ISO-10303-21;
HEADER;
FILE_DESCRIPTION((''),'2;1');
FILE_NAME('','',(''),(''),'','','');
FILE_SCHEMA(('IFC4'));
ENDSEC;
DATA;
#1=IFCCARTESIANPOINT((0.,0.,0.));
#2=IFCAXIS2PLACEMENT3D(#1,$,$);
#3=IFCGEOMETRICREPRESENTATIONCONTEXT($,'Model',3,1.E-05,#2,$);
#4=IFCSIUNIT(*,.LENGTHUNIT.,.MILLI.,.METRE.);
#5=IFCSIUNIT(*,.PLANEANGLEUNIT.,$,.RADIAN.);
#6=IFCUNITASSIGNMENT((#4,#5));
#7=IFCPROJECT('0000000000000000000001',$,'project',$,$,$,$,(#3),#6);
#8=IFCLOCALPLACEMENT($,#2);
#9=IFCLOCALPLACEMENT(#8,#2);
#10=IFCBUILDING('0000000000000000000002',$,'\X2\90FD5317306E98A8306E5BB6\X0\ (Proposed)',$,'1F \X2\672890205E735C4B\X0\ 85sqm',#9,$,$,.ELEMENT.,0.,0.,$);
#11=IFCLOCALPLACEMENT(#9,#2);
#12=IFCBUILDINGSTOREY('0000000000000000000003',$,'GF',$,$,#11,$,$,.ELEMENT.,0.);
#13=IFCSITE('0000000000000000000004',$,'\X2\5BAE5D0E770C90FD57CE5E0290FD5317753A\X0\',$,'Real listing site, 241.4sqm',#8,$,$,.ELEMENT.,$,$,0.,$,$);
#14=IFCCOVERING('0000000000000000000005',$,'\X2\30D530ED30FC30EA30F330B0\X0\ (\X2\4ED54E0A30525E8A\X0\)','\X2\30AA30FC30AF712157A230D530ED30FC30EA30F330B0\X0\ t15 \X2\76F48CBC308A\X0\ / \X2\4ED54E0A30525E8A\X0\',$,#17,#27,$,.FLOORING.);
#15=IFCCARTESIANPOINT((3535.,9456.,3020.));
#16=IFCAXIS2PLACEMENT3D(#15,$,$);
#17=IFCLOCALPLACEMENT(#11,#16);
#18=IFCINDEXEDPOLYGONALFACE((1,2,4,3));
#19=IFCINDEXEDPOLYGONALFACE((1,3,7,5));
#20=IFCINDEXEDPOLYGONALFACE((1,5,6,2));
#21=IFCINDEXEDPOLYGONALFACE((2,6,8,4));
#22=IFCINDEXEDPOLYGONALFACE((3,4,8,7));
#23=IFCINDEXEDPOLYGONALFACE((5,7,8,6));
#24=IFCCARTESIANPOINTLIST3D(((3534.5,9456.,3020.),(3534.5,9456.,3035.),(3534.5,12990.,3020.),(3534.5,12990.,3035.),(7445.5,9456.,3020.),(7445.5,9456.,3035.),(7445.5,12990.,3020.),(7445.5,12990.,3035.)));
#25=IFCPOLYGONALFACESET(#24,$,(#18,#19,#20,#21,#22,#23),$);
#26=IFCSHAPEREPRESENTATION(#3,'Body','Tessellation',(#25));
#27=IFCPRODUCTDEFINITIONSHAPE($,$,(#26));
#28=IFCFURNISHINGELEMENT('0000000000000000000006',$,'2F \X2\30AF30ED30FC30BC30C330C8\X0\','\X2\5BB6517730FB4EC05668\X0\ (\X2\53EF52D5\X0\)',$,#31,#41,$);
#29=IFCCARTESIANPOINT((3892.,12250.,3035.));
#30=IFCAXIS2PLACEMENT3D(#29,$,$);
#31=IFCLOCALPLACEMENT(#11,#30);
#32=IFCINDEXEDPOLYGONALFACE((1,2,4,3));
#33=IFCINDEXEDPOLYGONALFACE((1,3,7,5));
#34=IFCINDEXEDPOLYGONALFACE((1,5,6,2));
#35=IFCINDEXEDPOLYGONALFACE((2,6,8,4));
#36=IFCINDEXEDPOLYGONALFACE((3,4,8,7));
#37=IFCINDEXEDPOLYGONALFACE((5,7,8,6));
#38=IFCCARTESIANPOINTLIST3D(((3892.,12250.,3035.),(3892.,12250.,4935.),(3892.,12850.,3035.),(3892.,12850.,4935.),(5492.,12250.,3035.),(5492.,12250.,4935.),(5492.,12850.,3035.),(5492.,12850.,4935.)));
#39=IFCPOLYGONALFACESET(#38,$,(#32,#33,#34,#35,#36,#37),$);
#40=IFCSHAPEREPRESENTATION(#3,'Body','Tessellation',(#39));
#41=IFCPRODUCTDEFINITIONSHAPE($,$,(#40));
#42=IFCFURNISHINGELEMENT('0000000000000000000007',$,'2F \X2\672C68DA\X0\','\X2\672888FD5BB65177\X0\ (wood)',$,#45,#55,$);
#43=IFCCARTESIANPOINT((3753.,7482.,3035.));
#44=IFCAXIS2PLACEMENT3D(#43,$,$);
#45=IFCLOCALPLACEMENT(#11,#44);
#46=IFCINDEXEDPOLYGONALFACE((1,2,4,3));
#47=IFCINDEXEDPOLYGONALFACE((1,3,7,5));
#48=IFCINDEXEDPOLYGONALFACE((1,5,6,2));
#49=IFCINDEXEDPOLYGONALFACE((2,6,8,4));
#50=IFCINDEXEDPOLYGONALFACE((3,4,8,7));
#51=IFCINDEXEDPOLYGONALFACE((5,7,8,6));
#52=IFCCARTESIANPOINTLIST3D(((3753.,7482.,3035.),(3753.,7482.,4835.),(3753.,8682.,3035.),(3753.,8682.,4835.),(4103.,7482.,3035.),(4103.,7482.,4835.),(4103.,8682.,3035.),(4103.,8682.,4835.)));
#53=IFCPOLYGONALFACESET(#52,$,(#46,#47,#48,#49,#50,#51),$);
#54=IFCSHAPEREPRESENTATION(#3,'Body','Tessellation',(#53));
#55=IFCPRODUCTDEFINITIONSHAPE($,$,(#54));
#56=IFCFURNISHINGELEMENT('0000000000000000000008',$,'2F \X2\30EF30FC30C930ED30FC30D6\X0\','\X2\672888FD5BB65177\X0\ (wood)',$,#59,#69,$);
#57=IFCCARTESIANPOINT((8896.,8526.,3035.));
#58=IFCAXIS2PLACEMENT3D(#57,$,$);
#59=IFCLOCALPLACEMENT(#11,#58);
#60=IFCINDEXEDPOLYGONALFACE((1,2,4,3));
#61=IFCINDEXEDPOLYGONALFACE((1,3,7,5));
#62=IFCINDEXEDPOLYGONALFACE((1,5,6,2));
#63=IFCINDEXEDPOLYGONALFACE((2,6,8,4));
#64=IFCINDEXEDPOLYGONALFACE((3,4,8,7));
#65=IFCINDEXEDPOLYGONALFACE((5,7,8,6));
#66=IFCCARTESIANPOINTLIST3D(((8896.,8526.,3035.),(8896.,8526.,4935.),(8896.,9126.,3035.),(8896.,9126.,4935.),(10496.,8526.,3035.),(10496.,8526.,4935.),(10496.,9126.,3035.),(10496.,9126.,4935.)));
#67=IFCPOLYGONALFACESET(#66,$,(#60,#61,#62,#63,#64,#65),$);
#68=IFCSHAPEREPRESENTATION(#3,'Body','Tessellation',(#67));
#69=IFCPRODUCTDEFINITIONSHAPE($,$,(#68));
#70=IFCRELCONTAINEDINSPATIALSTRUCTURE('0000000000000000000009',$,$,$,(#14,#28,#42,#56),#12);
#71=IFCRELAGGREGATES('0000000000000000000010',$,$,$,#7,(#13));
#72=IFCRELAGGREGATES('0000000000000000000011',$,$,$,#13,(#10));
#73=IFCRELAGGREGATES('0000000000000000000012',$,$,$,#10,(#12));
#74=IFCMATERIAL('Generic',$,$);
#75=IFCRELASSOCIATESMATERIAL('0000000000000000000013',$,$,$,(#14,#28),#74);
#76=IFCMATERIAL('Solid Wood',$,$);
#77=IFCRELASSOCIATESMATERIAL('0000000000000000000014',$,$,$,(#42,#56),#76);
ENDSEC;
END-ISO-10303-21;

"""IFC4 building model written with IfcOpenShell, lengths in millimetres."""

from ifc_helpers import new_model, si_unit, frame, frame_2d, origin, place, context, project, spatial, rectangle, extrude, material, element, save


model = new_model("IFC4")

# Units and contexts
model_context = context("Model", 3, precision=1e-05, world=origin())
ifc_project = project(units=[si_unit("LENGTHUNIT", "METRE", prefix="MILLI"), si_unit("PLANEANGLEUNIT", "RADIAN")], contexts=[model_context])

# Site, building, storey
site_placement = place(None, origin())
site = spatial("IfcSite", under=ifc_project, at=site_placement, Name="宮崎県都城市都北町", ObjectType="Real listing site, 241.4sqm", CompositionType="ELEMENT", RefElevation=0.0)
building_placement = place(site_placement, origin())
building = spatial("IfcBuilding", under=site, at=building_placement, Name="都北の風の家 (Proposed)", ObjectType="1F 木造平屋 85sqm", CompositionType="ELEMENT", ElevationOfRefHeight=0.0, ElevationOfTerrain=0.0)
storey_placement = place(building_placement, origin())
storey = spatial("IfcBuildingStorey", under=building, at=storey_placement, Name="GF", CompositionType="ELEMENT", Elevation=0.0)

# Shared definitions
ifc_material_1 = material(Name="Solid Wood")

# Shared definitions
ifc_material_2 = material(Name="Generic")

# Covering
covering_placement = place(storey_placement, frame((3535.0, 9456.0, 3020.0)))
element("IfcCovering", 1, at=covering_placement, inside=storey, material=ifc_material_2, Name="フローリング (仕上げ床)", Description="オーク無垢フローリング t15 直貼り / 仕上げ床", PredefinedType="FLOORING", context=model_context, shape_type="SweptSolid", body=[
    extrude(rectangle(XDim=3911.0, YDim=3534.0, at=frame_2d((1955.0, 1767.0))), frame((3535.0, 9456.0, 3020.0)), (0.0, 0.0, 1.0), 15.0),
])

# Furnishing elements
furnishing_1_placement = place(storey_placement, frame((3892.0, 12250.0, 3035.0)))
element("IfcFurnishingElement", 2, at=furnishing_1_placement, inside=storey, material=ifc_material_2, Name="2F クローゼット", Description="家具・什器 (可動)", context=model_context, shape_type="SweptSolid", body=[
    extrude(rectangle(XDim=1600.0, YDim=600.0, at=frame_2d((800.0, 300.0))), frame((3892.0, 12250.0, 3035.0)), (0.0, 0.0, 1.0), 1900.0),
])
furnishing_2_placement = place(storey_placement, frame((3753.0, 7482.0, 3035.0)))
element("IfcFurnishingElement", 3, at=furnishing_2_placement, inside=storey, material=ifc_material_1, Name="2F 本棚", Description="木製家具 (wood)", context=model_context, shape_type="SweptSolid", body=[
    extrude(rectangle(XDim=350.0, YDim=1200.0, at=frame_2d((175.0, 600.0))), frame((3753.0, 7482.0, 3035.0)), (0.0, 0.0, 1.0), 1800.0),
])
furnishing_3_placement = place(storey_placement, frame((8896.0, 8526.0, 3035.0)))
element("IfcFurnishingElement", 4, at=furnishing_3_placement, inside=storey, material=ifc_material_1, Name="2F ワードローブ", Description="木製家具 (wood)", context=model_context, shape_type="SweptSolid", body=[
    extrude(rectangle(XDim=1600.0, YDim=600.0, at=frame_2d((800.0, 300.0))), frame((8896.0, 8526.0, 3035.0)), (0.0, 0.0, 1.0), 1900.0),
])

save(model, "model.ifc")
